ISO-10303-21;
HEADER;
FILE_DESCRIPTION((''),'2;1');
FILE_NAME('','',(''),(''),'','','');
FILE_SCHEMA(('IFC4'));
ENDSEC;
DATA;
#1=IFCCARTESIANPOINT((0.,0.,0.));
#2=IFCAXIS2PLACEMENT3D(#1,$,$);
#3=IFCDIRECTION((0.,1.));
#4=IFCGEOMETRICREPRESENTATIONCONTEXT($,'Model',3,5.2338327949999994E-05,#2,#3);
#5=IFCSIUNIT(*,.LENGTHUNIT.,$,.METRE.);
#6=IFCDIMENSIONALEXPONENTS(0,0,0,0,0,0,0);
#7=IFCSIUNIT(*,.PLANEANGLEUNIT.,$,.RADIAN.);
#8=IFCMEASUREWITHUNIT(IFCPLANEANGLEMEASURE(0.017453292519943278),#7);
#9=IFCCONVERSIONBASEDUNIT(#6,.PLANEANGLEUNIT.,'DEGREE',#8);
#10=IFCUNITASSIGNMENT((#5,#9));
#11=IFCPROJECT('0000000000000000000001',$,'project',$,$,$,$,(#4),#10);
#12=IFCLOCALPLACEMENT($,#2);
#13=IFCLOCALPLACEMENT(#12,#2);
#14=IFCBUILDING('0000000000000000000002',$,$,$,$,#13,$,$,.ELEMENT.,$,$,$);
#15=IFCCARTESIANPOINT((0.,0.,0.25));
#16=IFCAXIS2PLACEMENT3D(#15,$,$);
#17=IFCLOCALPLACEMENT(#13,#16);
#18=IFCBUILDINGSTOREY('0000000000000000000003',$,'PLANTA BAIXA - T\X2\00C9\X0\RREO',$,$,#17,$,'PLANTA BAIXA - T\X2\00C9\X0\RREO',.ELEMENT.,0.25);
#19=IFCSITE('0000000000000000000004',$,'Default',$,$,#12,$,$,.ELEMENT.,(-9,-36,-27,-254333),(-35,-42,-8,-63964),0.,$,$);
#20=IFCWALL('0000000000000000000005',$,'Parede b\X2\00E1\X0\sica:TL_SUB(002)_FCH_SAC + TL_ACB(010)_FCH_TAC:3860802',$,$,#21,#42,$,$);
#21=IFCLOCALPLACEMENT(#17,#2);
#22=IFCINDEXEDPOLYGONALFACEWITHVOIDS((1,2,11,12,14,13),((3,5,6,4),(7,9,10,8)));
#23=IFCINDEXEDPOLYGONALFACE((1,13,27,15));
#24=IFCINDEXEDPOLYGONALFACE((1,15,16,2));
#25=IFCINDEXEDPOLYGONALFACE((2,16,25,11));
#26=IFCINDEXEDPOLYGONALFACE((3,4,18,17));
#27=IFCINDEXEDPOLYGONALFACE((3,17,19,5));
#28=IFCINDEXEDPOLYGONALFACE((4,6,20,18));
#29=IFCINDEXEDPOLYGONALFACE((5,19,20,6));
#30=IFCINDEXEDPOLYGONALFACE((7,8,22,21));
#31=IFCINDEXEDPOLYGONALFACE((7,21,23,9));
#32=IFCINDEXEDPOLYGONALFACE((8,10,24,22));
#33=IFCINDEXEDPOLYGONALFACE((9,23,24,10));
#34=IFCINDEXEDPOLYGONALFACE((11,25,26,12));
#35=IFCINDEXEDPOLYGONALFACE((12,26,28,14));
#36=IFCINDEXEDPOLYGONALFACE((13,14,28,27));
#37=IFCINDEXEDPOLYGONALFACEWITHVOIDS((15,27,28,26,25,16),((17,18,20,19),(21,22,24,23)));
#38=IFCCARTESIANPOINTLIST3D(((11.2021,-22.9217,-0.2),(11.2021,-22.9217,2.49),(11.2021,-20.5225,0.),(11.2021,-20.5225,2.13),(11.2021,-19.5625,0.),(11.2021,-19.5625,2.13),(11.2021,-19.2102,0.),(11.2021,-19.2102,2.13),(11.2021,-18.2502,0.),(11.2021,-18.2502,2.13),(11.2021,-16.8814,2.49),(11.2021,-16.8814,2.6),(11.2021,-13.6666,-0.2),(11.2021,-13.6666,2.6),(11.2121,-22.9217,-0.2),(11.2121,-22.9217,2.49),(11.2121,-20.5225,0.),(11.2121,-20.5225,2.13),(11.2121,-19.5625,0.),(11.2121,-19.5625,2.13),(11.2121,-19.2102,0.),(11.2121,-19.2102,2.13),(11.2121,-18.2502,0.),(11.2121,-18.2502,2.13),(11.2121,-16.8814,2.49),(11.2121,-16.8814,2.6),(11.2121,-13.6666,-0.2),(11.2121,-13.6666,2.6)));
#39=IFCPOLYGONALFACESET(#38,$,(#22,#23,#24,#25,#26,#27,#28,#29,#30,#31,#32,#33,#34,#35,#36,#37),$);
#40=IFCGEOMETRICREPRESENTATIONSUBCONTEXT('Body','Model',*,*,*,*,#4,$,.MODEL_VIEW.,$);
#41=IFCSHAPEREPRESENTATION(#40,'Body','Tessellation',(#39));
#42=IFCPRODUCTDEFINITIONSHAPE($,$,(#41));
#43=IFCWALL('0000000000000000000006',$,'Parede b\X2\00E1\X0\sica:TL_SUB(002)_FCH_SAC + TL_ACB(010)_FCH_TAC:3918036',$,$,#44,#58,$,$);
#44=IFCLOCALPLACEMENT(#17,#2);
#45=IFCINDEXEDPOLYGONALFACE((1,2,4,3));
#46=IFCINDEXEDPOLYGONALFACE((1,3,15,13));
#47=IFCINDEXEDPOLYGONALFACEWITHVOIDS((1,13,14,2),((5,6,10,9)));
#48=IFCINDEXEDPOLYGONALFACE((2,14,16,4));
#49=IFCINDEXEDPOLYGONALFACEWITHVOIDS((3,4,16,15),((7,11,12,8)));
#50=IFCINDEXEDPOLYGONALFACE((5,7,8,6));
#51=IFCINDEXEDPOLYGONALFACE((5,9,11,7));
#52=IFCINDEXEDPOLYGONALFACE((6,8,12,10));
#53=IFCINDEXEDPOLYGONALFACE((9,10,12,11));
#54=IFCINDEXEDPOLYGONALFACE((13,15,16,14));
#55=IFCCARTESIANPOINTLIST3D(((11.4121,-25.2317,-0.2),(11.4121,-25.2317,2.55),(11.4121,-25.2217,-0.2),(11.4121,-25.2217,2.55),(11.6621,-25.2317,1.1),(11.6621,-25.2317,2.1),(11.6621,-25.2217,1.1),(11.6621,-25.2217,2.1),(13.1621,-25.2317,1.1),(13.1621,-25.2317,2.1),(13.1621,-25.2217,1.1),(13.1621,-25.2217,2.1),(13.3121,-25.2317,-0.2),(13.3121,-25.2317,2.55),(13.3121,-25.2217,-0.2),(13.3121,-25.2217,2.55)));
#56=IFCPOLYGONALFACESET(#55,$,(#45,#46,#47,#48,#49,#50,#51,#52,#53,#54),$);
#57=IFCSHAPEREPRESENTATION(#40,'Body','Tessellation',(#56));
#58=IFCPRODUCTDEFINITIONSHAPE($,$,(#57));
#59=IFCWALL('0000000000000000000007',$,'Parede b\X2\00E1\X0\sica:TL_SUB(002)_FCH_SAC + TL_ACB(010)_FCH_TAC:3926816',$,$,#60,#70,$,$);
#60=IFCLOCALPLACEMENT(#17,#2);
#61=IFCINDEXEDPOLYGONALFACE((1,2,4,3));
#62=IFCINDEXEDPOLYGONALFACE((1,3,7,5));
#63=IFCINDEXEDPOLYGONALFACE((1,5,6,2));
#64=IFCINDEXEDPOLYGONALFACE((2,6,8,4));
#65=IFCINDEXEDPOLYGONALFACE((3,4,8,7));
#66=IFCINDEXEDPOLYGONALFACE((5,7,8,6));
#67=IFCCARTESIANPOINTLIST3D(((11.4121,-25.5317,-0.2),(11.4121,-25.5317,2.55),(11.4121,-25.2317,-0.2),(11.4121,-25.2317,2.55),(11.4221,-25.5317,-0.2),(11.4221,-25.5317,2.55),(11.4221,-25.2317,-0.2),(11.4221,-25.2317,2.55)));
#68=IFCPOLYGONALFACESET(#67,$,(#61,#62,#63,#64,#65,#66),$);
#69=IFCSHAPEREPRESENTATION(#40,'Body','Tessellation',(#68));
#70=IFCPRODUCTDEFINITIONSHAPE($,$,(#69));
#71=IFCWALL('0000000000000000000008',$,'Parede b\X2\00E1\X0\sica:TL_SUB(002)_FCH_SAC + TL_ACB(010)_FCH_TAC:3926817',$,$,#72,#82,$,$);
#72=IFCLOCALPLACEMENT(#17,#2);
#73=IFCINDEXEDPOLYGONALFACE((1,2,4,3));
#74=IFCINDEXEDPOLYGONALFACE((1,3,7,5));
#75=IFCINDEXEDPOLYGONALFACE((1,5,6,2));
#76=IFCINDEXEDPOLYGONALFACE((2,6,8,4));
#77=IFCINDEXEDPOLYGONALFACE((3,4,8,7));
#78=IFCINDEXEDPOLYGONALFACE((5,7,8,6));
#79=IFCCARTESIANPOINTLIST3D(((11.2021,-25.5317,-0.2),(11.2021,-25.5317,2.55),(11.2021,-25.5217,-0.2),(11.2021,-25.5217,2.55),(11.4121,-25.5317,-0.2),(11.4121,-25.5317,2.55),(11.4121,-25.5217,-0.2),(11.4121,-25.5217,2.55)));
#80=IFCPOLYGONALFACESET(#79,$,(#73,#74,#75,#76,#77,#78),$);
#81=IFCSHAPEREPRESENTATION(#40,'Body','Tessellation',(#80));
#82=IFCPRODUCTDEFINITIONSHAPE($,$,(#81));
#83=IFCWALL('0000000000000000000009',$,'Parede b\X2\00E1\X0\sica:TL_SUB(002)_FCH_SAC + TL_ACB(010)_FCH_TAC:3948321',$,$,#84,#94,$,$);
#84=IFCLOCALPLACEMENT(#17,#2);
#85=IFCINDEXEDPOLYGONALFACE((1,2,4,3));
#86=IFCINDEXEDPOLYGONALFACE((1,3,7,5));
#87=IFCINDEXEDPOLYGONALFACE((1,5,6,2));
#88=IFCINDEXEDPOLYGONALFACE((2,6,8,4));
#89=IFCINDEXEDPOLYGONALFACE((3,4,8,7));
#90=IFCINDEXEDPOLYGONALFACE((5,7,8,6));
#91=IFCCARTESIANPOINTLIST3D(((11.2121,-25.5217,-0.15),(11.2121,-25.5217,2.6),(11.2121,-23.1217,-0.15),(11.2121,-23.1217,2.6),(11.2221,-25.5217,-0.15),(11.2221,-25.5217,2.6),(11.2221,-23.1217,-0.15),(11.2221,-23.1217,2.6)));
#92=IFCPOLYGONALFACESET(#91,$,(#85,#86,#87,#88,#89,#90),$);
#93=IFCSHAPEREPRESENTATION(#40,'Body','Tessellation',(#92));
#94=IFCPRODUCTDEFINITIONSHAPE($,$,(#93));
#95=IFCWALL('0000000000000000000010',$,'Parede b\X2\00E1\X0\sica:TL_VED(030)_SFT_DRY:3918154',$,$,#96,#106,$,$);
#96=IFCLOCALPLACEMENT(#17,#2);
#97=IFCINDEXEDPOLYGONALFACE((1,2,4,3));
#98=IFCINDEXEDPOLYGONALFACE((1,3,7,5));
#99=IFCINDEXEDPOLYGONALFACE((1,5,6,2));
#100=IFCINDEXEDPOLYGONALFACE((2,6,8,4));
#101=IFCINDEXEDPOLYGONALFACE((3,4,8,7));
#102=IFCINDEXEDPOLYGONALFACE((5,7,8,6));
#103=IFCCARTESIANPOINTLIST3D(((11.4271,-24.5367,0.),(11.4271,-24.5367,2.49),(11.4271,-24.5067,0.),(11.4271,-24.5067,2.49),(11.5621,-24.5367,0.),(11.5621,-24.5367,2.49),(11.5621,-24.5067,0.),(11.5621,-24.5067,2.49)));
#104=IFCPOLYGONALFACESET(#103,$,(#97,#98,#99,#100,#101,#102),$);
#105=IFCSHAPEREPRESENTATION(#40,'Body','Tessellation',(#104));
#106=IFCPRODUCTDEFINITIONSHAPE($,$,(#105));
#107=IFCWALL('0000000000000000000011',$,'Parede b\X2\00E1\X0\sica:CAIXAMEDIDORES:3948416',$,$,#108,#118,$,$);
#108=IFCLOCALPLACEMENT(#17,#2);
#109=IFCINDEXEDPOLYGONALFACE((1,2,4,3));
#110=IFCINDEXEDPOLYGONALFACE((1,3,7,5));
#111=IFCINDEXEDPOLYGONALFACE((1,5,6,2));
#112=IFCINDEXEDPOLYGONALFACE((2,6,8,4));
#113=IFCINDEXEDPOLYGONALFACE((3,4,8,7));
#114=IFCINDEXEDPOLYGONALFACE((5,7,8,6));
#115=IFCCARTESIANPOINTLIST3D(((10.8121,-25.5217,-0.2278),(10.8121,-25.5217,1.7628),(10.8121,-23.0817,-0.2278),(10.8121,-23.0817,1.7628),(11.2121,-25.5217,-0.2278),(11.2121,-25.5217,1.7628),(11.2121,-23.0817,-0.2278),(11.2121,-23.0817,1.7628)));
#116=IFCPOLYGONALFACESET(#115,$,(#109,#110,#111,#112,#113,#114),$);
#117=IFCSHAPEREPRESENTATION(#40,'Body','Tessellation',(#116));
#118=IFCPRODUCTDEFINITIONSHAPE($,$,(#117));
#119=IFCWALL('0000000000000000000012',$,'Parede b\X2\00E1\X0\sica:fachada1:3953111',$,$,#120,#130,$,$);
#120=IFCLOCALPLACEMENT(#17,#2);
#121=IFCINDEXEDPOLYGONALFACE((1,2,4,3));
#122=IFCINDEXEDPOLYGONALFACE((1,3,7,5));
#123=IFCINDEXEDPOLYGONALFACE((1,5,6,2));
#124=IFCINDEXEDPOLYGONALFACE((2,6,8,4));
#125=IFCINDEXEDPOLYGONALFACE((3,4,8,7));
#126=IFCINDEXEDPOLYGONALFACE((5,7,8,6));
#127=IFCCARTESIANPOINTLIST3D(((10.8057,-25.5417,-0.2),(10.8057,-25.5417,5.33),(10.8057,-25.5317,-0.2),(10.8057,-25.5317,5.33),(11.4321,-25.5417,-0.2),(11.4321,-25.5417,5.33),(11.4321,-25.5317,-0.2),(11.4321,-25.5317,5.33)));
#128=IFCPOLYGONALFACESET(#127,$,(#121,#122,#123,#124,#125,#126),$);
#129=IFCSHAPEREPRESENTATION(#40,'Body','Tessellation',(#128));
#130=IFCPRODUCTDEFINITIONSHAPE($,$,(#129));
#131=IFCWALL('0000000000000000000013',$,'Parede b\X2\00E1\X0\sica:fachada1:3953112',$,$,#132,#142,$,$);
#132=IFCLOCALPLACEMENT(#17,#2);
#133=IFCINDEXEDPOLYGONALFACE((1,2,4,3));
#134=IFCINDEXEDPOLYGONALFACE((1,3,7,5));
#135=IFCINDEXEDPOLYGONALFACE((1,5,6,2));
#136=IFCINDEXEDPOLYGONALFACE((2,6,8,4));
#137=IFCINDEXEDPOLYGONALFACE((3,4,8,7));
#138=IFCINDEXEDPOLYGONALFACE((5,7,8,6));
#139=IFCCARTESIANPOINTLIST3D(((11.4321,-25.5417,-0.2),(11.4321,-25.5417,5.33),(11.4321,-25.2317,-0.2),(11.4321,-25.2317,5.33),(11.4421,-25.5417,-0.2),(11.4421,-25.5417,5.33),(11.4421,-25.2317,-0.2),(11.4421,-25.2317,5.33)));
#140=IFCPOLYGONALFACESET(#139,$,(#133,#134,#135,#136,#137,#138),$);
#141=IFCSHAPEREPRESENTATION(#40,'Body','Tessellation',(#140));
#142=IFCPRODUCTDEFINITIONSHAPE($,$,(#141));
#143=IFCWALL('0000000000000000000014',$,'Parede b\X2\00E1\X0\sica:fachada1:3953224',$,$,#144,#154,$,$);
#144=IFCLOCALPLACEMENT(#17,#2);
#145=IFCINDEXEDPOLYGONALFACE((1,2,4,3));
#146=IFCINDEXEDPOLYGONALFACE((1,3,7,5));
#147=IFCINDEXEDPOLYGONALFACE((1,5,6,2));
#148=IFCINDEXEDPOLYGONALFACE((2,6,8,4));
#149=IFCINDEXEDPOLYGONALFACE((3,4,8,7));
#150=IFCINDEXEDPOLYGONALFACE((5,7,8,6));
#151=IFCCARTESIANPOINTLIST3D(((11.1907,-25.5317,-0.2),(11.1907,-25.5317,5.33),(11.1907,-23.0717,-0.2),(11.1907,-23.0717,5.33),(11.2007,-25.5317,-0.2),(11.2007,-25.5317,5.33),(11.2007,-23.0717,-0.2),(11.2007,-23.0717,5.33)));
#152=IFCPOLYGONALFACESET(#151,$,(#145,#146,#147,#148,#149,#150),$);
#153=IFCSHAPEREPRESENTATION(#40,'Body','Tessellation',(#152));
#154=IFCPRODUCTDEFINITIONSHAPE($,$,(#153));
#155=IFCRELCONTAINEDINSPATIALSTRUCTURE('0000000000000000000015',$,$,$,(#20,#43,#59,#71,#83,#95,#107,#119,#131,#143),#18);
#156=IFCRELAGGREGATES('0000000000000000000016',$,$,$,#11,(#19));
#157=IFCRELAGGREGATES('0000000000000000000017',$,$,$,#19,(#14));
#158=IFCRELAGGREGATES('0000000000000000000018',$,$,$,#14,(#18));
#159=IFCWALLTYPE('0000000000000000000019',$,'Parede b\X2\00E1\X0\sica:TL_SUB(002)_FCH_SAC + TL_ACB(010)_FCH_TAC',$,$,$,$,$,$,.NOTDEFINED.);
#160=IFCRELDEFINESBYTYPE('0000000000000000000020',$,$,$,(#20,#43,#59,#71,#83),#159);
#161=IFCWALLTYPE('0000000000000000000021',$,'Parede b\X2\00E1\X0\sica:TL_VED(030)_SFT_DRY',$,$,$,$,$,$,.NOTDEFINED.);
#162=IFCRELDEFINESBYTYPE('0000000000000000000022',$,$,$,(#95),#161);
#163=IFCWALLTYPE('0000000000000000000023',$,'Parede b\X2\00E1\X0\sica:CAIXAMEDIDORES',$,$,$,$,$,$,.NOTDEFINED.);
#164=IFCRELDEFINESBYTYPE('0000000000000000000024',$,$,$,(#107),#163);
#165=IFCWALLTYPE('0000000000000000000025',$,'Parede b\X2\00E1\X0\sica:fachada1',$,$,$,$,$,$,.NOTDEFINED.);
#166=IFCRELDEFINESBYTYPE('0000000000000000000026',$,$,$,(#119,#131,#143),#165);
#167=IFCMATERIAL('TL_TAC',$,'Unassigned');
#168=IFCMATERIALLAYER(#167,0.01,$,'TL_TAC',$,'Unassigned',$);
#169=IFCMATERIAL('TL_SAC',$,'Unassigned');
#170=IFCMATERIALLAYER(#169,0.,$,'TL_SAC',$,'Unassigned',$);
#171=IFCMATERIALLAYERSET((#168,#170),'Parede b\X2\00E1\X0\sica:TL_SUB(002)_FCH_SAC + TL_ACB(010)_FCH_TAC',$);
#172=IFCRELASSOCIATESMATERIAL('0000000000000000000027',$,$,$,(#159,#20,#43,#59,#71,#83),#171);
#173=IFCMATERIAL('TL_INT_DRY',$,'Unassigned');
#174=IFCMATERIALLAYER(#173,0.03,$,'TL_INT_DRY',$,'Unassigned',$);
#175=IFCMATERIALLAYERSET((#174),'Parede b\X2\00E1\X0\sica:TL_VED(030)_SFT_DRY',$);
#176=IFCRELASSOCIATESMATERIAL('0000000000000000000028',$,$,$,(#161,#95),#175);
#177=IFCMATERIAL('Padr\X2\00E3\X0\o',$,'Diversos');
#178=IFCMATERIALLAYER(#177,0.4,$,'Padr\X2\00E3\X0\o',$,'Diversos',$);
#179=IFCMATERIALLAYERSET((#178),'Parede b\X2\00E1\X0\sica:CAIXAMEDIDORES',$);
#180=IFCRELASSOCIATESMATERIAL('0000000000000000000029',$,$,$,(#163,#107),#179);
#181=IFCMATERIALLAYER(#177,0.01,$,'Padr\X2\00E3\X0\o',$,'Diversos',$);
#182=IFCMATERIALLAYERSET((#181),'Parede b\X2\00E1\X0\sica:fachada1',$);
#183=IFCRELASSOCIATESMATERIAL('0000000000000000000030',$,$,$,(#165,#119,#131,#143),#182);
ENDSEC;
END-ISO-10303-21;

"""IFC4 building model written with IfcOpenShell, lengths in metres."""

from ifc_helpers import new_model, entity, si_unit, converted_unit, direction, frame, frame_2d, origin, place, context, subcontext, project, spatial, polyline, rectangle, extrude, clip, bounded_halfspace, material, layer, layer_set, layer_usage, type_object, element, save


model = new_model("IFC4")

# Units and contexts
model_context = context("Model", 3, precision=5.2338327949999994e-05, world=origin(), true_north=direction((0.0, 1.0)))
body_context = subcontext(model_context, "Body", "Model", "MODEL_VIEW")
ifc_project = project(units=[si_unit("LENGTHUNIT", "METRE"), converted_unit("PLANEANGLEUNIT", "DEGREE", entity("IfcPlaneAngleMeasure", 0.017453292519943278), si_unit("PLANEANGLEUNIT", "RADIAN"), dimensions=[0, 0, 0, 0, 0, 0, 0])], contexts=[model_context])

# Site, building, storey
site_placement = place(None, frame((0.0, 0.0, 0.0)))
site = spatial("IfcSite", under=ifc_project, at=site_placement, Name="Default", CompositionType="ELEMENT", RefLatitude=(-9, -36, -27, -254333), RefLongitude=(-35, -42, -8, -63964), RefElevation=0.0)
building_placement = place(site_placement, origin())
building = spatial("IfcBuilding", under=site, at=building_placement, CompositionType="ELEMENT")
storey_placement = place(building_placement, frame((0.0, 0.0, 0.25)))
storey = spatial("IfcBuildingStorey", under=building, at=storey_placement, Name="PLANTA BAIXA - TÉRREO", LongName="PLANTA BAIXA - TÉRREO", CompositionType="ELEMENT", Elevation=0.25)

# Shared definitions
ifc_material_1 = material(Name="TL_SAC", Category="Unassigned")

# Shared definitions
ifc_material_2 = material(Name="TL_TAC", Category="Unassigned")
ifc_layer_1 = layer(ifc_material_2, 0.01, Name="TL_TAC", Category="Unassigned")
ifc_layer_2 = layer(ifc_material_1, 0.0, Name="TL_SAC", Category="Unassigned")
ifc_layer_set_1 = layer_set([ifc_layer_1, ifc_layer_2], Name="Parede básica:TL_SUB(002)_FCH_SAC + TL_ACB(010)_FCH_TAC")
wall_type_1 = type_object("IfcWallType", Name="Parede básica:TL_SUB(002)_FCH_SAC + TL_ACB(010)_FCH_TAC", PredefinedType="NOTDEFINED", material=ifc_layer_set_1)

# Wall, openings
ifc_layer_usage_1 = layer_usage(ifc_layer_set_1, "AXIS2", "POSITIVE", -0.005)
wall_1_placement = place(storey_placement, frame((11.2071, -22.9217, -0.2), z_axis=(0.0, 0.0, 1.0), x_axis=(0.0, 1.0, 0.0)))
wall_1 = element("IfcWall", 1, at=wall_1_placement, inside=storey, type_object=wall_type_1, material=ifc_layer_usage_1, Name="Parede básica:TL_SUB(002)_FCH_SAC + TL_ACB(010)_FCH_TAC:3860802", context=body_context, shape_type="Clipping", body=[
    clip(extrude(rectangle(XDim=9.2551, YDim=0.01, at=frame_2d((4.6276, 0.0), x_axis=(-1.0, 0.0))), origin(), (0.0, 0.0, 1.0), 2.8), bounded_halfspace(frame((0.0, -0.005, 2.69), z_axis=(0.0, 0.0, -1.0), x_axis=(-1.0, 0.0, 0.0)), True, frame((0.0, -0.005, 2.69)), polyline([(0.0, 0.0), (3.5354, 0.0), (6.0403, 0.0), (6.0403, 0.01), (0.01, 0.01), (0.0, 0.01), (0.0, 0.0)]))),
])
opening_1_placement = place(wall_1_placement, frame((22.9217, 11.2071, 0.2)))
element("IfcOpeningElement", 2, at=opening_1_placement, cuts=wall_1, PredefinedType="OPENING", context=body_context, shape_type="SweptSolid", body=[
    extrude(rectangle(XDim=2.13, YDim=0.96, at=frame_2d((0.0, 0.0), x_axis=(0.0, 1.0))), frame((-18.7302, -12.9361, 1.065), z_axis=(0.0, 1.0, 0.0), x_axis=(-1.0, 0.0, 0.0)), (0.0, 0.0, 1.0), 3.048),
])
opening_2_placement = place(wall_1_placement, frame((22.9217, 11.2071, 0.2)))
element("IfcOpeningElement", 3, at=opening_2_placement, cuts=wall_1, PredefinedType="OPENING", context=body_context, shape_type="SweptSolid", body=[
    extrude(rectangle(XDim=2.13, YDim=0.96, at=frame_2d((0.0, 0.0), x_axis=(1.0, 0.0))), frame((-20.0425, -12.9361, 1.065), z_axis=(0.0, 1.0, 0.0), x_axis=(0.0, 0.0, 1.0)), (0.0, 0.0, 1.0), 3.048),
])

# Wall, opening
ifc_layer_usage_2 = layer_usage(ifc_layer_set_1, "AXIS2", "NEGATIVE", 0.005)
wall_2_placement = place(storey_placement, frame((11.4121, -25.2267, -0.2)))
wall_2 = element("IfcWall", 4, at=wall_2_placement, inside=storey, type_object=wall_type_1, material=ifc_layer_usage_2, Name="Parede básica:TL_SUB(002)_FCH_SAC + TL_ACB(010)_FCH_TAC:3918036", context=body_context, shape_type="SweptSolid", body=[
    extrude(rectangle(XDim=1.9, YDim=0.01, at=frame_2d((0.95, 0.0), x_axis=(-1.0, 0.0))), origin(), (0.0, 0.0, 1.0), 2.75),
])
opening_3_placement = place(wall_2_placement, frame((-11.4121, 25.2267, 1.3)))
element("IfcOpeningElement", 5, at=opening_3_placement, cuts=wall_2, PredefinedType="OPENING", context=body_context, shape_type="SweptSolid", body=[
    extrude(rectangle(XDim=1.0, YDim=1.5, at=frame_2d((0.0, 0.0), x_axis=(0.0, 1.0))), frame((12.4121, -26.6457, 0.5), z_axis=(0.0, 1.0, 0.0), x_axis=(1.0, 0.0, 0.0)), (0.0, 0.0, 1.0), 3.048),
])

# Walls
ifc_layer_usage_3 = layer_usage(ifc_layer_set_1, "AXIS2", "POSITIVE", -0.005)
wall_3_placement = place(storey_placement, frame((11.4171, -25.2317, -0.2), z_axis=(0.0, 0.0, 1.0), x_axis=(0.0, -1.0, 0.0)))
element("IfcWall", 6, at=wall_3_placement, inside=storey, type_object=wall_type_1, material=ifc_layer_usage_3, Name="Parede básica:TL_SUB(002)_FCH_SAC + TL_ACB(010)_FCH_TAC:3926816", context=body_context, shape_type="SweptSolid", body=[
    extrude(rectangle(XDim=0.3, YDim=0.01, at=frame_2d((0.15, 0.0), x_axis=(-1.0, 0.0))), origin(), (0.0, 0.0, 1.0), 2.75),
])
ifc_layer_usage_4 = layer_usage(ifc_layer_set_1, "AXIS2", "POSITIVE", -0.005)
wall_4_placement = place(storey_placement, frame((11.4121, -25.5267, -0.2), z_axis=(0.0, 0.0, 1.0), x_axis=(-1.0, 0.0, 0.0)))
element("IfcWall", 7, at=wall_4_placement, inside=storey, type_object=wall_type_1, material=ifc_layer_usage_4, Name="Parede básica:TL_SUB(002)_FCH_SAC + TL_ACB(010)_FCH_TAC:3926817", context=body_context, shape_type="SweptSolid", body=[
    extrude(rectangle(XDim=0.21, YDim=0.01, at=frame_2d((0.105, 0.0), x_axis=(-1.0, 0.0))), origin(), (0.0, 0.0, 1.0), 2.75),
])
ifc_layer_usage_5 = layer_usage(ifc_layer_set_1, "AXIS2", "NEGATIVE", 0.005)
wall_5_placement = place(storey_placement, frame((11.2171, -25.5217, -0.15), z_axis=(0.0, 0.0, 1.0), x_axis=(0.0, 1.0, 0.0)))
element("IfcWall", 8, at=wall_5_placement, inside=storey, type_object=wall_type_1, material=ifc_layer_usage_5, Name="Parede básica:TL_SUB(002)_FCH_SAC + TL_ACB(010)_FCH_TAC:3948321", context=body_context, shape_type="SweptSolid", body=[
    extrude(rectangle(XDim=2.4, YDim=0.01, at=frame_2d((1.2, 0.0), x_axis=(-1.0, 0.0))), origin(), (0.0, 0.0, 1.0), 2.75),
])
ifc_material_3 = material(Name="TL_INT_DRY", Category="Unassigned")
ifc_layer_3 = layer(ifc_material_3, 0.03, Name="TL_INT_DRY", Category="Unassigned")
ifc_layer_set_2 = layer_set([ifc_layer_3], Name="Parede básica:TL_VED(030)_SFT_DRY")
ifc_layer_usage_6 = layer_usage(ifc_layer_set_2, "AXIS2", "POSITIVE", -0.015)
wall_type_2 = type_object("IfcWallType", Name="Parede básica:TL_VED(030)_SFT_DRY", PredefinedType="NOTDEFINED", material=ifc_layer_set_2)
wall_6_placement = place(storey_placement, frame((11.5621, -24.5217, 0.0), z_axis=(0.0, 0.0, 1.0), x_axis=(-1.0, 0.0, 0.0)))
element("IfcWall", 9, at=wall_6_placement, inside=storey, type_object=wall_type_2, material=ifc_layer_usage_6, Name="Parede básica:TL_VED(030)_SFT_DRY:3918154", context=body_context, shape_type="SweptSolid", body=[
    extrude(rectangle(XDim=0.135, YDim=0.03, at=frame_2d((0.0675, 0.0), x_axis=(-1.0, 0.0))), origin(), (0.0, 0.0, 1.0), 2.49),
])
ifc_material_4 = material(Name="Padrão", Category="Diversos")
ifc_layer_4 = layer(ifc_material_4, 0.4, Name="Padrão", Category="Diversos")
ifc_layer_set_3 = layer_set([ifc_layer_4], Name="Parede básica:CAIXAMEDIDORES")
ifc_layer_usage_7 = layer_usage(ifc_layer_set_3, "AXIS2", "NEGATIVE", 0.2)
wall_type_3 = type_object("IfcWallType", Name="Parede básica:CAIXAMEDIDORES", PredefinedType="NOTDEFINED", material=ifc_layer_set_3)
wall_7_placement = place(storey_placement, frame((11.0121, -23.0817, -0.2278), z_axis=(0.0, 0.0, 1.0), x_axis=(0.0, -1.0, 0.0)))
element("IfcWall", 10, at=wall_7_placement, inside=storey, type_object=wall_type_3, material=ifc_layer_usage_7, Name="Parede básica:CAIXAMEDIDORES:3948416", context=body_context, shape_type="SweptSolid", body=[
    extrude(rectangle(XDim=2.44, YDim=0.4, at=frame_2d((1.22, 0.0), x_axis=(-1.0, 0.0))), origin(), (0.0, 0.0, 1.0), 1.9905),
])
ifc_layer_5 = layer(ifc_material_4, 0.01, Name="Padrão", Category="Diversos")
ifc_layer_set_4 = layer_set([ifc_layer_5], Name="Parede básica:fachada1")
ifc_layer_usage_8 = layer_usage(ifc_layer_set_4, "AXIS2", "POSITIVE", -0.005)
wall_type_4 = type_object("IfcWallType", Name="Parede básica:fachada1", PredefinedType="NOTDEFINED", material=ifc_layer_set_4)
wall_8_placement = place(storey_placement, frame((11.4321, -25.5367, -0.2), z_axis=(0.0, 0.0, 1.0), x_axis=(-1.0, 0.0, 0.0)))
element("IfcWall", 11, at=wall_8_placement, inside=storey, type_object=wall_type_4, material=ifc_layer_usage_8, Name="Parede básica:fachada1:3953111", context=body_context, shape_type="SweptSolid", body=[
    extrude(rectangle(XDim=0.6264, YDim=0.01, at=frame_2d((0.3132, 0.0), x_axis=(-1.0, 0.0))), origin(), (0.0, 0.0, 1.0), 5.53),
])
ifc_layer_usage_9 = layer_usage(ifc_layer_set_4, "AXIS2", "POSITIVE", -0.005)
wall_9_placement = place(storey_placement, frame((11.4371, -25.2317, -0.2), z_axis=(0.0, 0.0, 1.0), x_axis=(0.0, -1.0, 0.0)))
element("IfcWall", 12, at=wall_9_placement, inside=storey, type_object=wall_type_4, material=ifc_layer_usage_9, Name="Parede básica:fachada1:3953112", context=body_context, shape_type="SweptSolid", body=[
    extrude(rectangle(XDim=0.31, YDim=0.01, at=frame_2d((0.155, 0.0), x_axis=(-1.0, 0.0))), origin(), (0.0, 0.0, 1.0), 5.53),
])
ifc_layer_usage_10 = layer_usage(ifc_layer_set_4, "AXIS2", "POSITIVE", -0.005)
wall_10_placement = place(storey_placement, frame((11.1957, -25.5317, -0.2), z_axis=(0.0, 0.0, 1.0), x_axis=(0.0, 1.0, 0.0)))
element("IfcWall", 13, at=wall_10_placement, inside=storey, type_object=wall_type_4, material=ifc_layer_usage_10, Name="Parede básica:fachada1:3953224", context=body_context, shape_type="SweptSolid", body=[
    extrude(rectangle(XDim=2.46, YDim=0.01, at=frame_2d((1.23, 0.0), x_axis=(-1.0, 0.0))), origin(), (0.0, 0.0, 1.0), 5.53),
])

save(model, "model.ifc")
